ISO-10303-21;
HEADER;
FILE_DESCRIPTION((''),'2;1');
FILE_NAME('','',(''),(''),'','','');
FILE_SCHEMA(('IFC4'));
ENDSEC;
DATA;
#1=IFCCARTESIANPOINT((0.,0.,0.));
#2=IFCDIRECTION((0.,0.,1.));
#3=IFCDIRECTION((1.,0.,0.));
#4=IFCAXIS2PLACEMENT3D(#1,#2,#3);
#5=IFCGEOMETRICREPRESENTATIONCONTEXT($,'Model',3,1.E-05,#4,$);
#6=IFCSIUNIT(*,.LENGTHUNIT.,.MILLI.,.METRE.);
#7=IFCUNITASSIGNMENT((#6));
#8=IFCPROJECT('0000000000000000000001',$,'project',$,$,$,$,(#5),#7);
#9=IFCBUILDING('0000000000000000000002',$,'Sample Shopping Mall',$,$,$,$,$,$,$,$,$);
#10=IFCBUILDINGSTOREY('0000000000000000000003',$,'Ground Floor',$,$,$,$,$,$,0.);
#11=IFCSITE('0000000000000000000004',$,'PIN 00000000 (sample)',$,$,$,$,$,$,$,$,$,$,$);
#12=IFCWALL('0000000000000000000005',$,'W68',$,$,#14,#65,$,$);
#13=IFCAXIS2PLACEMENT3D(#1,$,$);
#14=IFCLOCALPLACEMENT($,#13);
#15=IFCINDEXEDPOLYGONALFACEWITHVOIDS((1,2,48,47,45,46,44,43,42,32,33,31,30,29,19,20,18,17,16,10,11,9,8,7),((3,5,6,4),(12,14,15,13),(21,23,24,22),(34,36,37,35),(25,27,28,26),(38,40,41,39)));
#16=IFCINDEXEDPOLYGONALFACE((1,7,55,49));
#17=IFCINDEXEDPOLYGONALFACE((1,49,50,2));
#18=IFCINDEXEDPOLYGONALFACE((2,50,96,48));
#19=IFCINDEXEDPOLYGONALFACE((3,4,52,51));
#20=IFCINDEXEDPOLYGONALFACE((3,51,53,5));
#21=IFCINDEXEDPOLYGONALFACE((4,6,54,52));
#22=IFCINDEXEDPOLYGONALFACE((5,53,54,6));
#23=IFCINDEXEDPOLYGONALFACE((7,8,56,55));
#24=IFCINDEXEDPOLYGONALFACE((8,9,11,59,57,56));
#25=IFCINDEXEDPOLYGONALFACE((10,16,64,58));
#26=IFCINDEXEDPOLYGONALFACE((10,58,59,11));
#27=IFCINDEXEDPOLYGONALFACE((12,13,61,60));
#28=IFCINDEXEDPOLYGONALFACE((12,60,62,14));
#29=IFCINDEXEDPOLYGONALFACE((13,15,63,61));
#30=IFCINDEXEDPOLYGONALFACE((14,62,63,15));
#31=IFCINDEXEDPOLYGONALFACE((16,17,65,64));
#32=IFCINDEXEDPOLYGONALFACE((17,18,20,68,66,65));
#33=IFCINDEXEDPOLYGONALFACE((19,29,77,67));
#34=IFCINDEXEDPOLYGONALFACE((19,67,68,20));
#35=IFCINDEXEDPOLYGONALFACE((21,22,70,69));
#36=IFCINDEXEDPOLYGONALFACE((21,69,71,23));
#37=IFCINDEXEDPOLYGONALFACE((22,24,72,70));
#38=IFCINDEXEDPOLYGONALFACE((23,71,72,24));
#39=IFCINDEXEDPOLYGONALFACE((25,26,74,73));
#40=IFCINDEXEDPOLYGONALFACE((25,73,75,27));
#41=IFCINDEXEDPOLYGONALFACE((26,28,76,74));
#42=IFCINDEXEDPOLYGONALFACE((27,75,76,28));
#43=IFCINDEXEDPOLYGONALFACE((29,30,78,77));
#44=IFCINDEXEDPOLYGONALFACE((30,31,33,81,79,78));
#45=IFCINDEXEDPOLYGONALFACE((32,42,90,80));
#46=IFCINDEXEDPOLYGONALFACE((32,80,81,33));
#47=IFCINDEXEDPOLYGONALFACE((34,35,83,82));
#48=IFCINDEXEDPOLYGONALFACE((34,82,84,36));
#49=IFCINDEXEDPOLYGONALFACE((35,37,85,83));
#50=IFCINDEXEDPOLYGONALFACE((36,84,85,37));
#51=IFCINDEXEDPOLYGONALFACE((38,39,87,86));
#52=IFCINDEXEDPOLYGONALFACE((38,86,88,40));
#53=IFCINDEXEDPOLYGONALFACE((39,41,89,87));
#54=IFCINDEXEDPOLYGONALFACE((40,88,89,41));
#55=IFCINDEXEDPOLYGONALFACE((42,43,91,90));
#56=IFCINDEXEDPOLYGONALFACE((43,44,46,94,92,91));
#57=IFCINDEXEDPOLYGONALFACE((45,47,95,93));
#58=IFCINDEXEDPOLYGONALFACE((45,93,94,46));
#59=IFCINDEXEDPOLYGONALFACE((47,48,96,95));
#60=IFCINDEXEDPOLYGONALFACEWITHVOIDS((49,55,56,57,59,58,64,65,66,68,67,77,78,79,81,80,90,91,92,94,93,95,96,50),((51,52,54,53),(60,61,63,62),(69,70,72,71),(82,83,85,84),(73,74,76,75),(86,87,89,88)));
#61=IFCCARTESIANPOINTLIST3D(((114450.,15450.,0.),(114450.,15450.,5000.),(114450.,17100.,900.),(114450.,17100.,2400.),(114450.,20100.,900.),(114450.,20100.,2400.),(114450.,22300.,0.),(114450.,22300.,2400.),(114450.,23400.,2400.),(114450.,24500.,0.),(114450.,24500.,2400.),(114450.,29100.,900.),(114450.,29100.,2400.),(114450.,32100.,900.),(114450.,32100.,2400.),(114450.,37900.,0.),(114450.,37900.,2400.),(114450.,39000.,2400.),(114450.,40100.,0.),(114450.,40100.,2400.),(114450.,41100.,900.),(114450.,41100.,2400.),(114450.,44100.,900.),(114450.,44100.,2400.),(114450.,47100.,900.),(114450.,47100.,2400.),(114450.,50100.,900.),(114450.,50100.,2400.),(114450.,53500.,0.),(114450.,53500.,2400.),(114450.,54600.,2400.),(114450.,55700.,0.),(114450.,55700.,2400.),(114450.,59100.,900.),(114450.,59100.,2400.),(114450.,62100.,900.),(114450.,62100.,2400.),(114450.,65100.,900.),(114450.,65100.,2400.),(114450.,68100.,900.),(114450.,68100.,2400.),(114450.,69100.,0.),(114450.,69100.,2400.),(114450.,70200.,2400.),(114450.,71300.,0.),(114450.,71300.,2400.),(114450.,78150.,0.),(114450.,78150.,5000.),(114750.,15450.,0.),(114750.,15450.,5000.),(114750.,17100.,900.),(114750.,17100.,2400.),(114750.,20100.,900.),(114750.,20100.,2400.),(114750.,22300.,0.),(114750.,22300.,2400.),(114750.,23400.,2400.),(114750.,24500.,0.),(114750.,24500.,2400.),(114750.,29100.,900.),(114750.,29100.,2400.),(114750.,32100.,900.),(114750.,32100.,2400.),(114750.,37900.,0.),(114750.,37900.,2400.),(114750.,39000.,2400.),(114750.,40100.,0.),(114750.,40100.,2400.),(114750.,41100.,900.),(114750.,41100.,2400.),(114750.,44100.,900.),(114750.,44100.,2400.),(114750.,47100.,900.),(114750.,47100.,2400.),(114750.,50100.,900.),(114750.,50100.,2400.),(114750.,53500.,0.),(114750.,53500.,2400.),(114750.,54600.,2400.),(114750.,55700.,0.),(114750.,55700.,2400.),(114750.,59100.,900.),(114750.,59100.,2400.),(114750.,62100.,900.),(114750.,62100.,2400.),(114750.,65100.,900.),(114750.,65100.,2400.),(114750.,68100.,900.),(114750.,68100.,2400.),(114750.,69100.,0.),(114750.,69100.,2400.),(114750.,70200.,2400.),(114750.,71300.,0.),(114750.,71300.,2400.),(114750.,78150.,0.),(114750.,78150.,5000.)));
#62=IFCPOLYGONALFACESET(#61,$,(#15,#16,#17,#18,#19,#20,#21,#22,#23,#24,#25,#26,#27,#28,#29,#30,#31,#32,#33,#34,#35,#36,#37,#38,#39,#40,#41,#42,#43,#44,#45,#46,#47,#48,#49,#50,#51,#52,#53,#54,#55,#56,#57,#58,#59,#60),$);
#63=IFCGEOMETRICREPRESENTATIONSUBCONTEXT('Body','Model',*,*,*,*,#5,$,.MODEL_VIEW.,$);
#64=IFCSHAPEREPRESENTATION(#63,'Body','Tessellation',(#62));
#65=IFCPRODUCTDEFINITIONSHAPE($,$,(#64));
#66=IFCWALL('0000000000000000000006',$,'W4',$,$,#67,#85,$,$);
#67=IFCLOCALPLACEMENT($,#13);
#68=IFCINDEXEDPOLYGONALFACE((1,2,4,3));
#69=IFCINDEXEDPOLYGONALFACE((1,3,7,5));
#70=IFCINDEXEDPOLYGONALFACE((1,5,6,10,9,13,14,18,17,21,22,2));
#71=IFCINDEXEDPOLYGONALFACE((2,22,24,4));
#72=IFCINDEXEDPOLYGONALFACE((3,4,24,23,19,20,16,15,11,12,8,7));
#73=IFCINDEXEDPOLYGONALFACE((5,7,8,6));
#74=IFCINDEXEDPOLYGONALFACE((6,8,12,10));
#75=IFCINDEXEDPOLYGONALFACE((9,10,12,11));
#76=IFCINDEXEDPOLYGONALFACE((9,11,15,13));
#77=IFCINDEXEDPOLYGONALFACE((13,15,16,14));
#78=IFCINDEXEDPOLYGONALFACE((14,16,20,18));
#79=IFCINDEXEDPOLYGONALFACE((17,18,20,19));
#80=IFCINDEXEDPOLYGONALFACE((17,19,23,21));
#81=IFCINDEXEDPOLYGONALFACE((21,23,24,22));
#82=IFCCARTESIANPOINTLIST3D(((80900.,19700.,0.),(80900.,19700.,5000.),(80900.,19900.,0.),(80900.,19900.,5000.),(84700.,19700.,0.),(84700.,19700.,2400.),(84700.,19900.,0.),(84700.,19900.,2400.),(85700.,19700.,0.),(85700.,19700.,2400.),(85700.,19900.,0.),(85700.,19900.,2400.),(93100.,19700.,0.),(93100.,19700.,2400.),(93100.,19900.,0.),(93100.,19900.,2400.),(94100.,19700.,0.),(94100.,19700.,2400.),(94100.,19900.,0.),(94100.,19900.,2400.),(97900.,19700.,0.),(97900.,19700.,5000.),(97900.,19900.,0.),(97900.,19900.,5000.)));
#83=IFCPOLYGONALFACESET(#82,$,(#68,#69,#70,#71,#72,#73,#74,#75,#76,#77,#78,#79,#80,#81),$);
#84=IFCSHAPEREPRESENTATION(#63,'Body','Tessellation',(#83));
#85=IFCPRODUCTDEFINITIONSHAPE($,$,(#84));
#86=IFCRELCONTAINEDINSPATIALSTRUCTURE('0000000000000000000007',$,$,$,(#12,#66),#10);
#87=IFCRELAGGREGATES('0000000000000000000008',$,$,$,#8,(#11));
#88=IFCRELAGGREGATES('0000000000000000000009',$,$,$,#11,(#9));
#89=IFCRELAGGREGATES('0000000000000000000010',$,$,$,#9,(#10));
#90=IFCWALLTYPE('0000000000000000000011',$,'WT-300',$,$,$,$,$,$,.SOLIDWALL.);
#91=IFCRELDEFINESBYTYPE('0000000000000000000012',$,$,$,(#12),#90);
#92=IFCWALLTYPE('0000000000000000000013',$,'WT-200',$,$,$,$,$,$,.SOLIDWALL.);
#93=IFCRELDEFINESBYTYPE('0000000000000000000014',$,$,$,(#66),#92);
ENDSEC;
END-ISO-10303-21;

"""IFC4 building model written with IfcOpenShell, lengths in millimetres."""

from ifc_helpers import new_model, si_unit, frame, origin_with_axes, place, context, subcontext, project, spatial, indexed_curve, outline, extrude, type_object, element, save


model = new_model("IFC4")

# Units and contexts
model_context = context("Model", 3, precision=1e-05, world=origin_with_axes())
body_context = subcontext(model_context, "Body", "Model", "MODEL_VIEW")
ifc_project = project(units=[si_unit("LENGTHUNIT", "METRE", prefix="MILLI")], contexts=[model_context])

# Site, building, storey
site = spatial("IfcSite", under=ifc_project, Name="PIN 00000000 (sample)")
building = spatial("IfcBuilding", under=site, Name="Sample Shopping Mall")
storey = spatial("IfcBuildingStorey", under=building, Name="Ground Floor", Elevation=0.0)

# Walls, openings
wall_type_1 = type_object("IfcWallType", Name="WT-300", PredefinedType="SOLIDWALL")
wall_1_placement = place(None, frame((114750.0, 15450.0, 0.0), z_axis=(0.0, 0.0, 1.0), x_axis=(0.0, 1.0, 0.0)))
wall_1 = element("IfcWall", 1, at=wall_1_placement, inside=storey, type_object=wall_type_1, Name="W68", context=body_context, shape_type="SweptSolid", body=[
    extrude(outline(indexed_curve([(0.0, 0.0), (0.0, 300.0), (62700.0, 300.0), (62700.0, 0.0), (0.0, 0.0)], self_intersect=False)), origin_with_axes(), (0.0, 0.0, 1.0), 5000.0),
])
opening_1_placement = place(wall_1_placement, frame((6850.0, -100.0, 0.0), z_axis=(0.0, 0.0, 1.0), x_axis=(1.0, 0.0, 0.0)))
element("IfcOpeningElement", 2, at=opening_1_placement, cuts=wall_1, context=body_context, shape_type="SweptSolid", body=[
    extrude(outline(indexed_curve([(0.0, 0.0), (0.0, 500.0), (1100.0, 500.0), (1100.0, 0.0), (0.0, 0.0)], self_intersect=False)), origin_with_axes(), (0.0, 0.0, 1.0), 2400.0),
])
opening_2_placement = place(wall_1_placement, frame((7950.0, -100.0, 0.0), z_axis=(0.0, 0.0, 1.0), x_axis=(1.0, 0.0, 0.0)))
element("IfcOpeningElement", 3, at=opening_2_placement, cuts=wall_1, context=body_context, shape_type="SweptSolid", body=[
    extrude(outline(indexed_curve([(0.0, 0.0), (0.0, 500.0), (1100.0, 500.0), (1100.0, 0.0), (0.0, 0.0)], self_intersect=False)), origin_with_axes(), (0.0, 0.0, 1.0), 2400.0),
])
opening_3_placement = place(wall_1_placement, frame((22450.0, -100.0, 0.0), z_axis=(0.0, 0.0, 1.0), x_axis=(1.0, 0.0, 0.0)))
element("IfcOpeningElement", 4, at=opening_3_placement, cuts=wall_1, context=body_context, shape_type="SweptSolid", body=[
    extrude(outline(indexed_curve([(0.0, 0.0), (0.0, 500.0), (1100.0, 500.0), (1100.0, 0.0), (0.0, 0.0)], self_intersect=False)), origin_with_axes(), (0.0, 0.0, 1.0), 2400.0),
])
opening_4_placement = place(wall_1_placement, frame((23550.0, -100.0, 0.0), z_axis=(0.0, 0.0, 1.0), x_axis=(1.0, 0.0, 0.0)))
element("IfcOpeningElement", 5, at=opening_4_placement, cuts=wall_1, context=body_context, shape_type="SweptSolid", body=[
    extrude(outline(indexed_curve([(0.0, 0.0), (0.0, 500.0), (1100.0, 500.0), (1100.0, 0.0), (0.0, 0.0)], self_intersect=False)), origin_with_axes(), (0.0, 0.0, 1.0), 2400.0),
])
opening_5_placement = place(wall_1_placement, frame((38050.0, -100.0, 0.0), z_axis=(0.0, 0.0, 1.0), x_axis=(1.0, 0.0, 0.0)))
element("IfcOpeningElement", 6, at=opening_5_placement, cuts=wall_1, context=body_context, shape_type="SweptSolid", body=[
    extrude(outline(indexed_curve([(0.0, 0.0), (0.0, 500.0), (1100.0, 500.0), (1100.0, 0.0), (0.0, 0.0)], self_intersect=False)), origin_with_axes(), (0.0, 0.0, 1.0), 2400.0),
])
opening_6_placement = place(wall_1_placement, frame((39150.0, -100.0, 0.0), z_axis=(0.0, 0.0, 1.0), x_axis=(1.0, 0.0, 0.0)))
element("IfcOpeningElement", 7, at=opening_6_placement, cuts=wall_1, context=body_context, shape_type="SweptSolid", body=[
    extrude(outline(indexed_curve([(0.0, 0.0), (0.0, 500.0), (1100.0, 500.0), (1100.0, 0.0), (0.0, 0.0)], self_intersect=False)), origin_with_axes(), (0.0, 0.0, 1.0), 2400.0),
])
opening_7_placement = place(wall_1_placement, frame((53650.0, -100.0, 0.0), z_axis=(0.0, 0.0, 1.0), x_axis=(1.0, 0.0, 0.0)))
element("IfcOpeningElement", 8, at=opening_7_placement, cuts=wall_1, context=body_context, shape_type="SweptSolid", body=[
    extrude(outline(indexed_curve([(0.0, 0.0), (0.0, 500.0), (1100.0, 500.0), (1100.0, 0.0), (0.0, 0.0)], self_intersect=False)), origin_with_axes(), (0.0, 0.0, 1.0), 2400.0),
])
opening_8_placement = place(wall_1_placement, frame((54750.0, -100.0, 0.0), z_axis=(0.0, 0.0, 1.0), x_axis=(1.0, 0.0, 0.0)))
element("IfcOpeningElement", 9, at=opening_8_placement, cuts=wall_1, context=body_context, shape_type="SweptSolid", body=[
    extrude(outline(indexed_curve([(0.0, 0.0), (0.0, 500.0), (1100.0, 500.0), (1100.0, 0.0), (0.0, 0.0)], self_intersect=False)), origin_with_axes(), (0.0, 0.0, 1.0), 2400.0),
])
opening_9_placement = place(wall_1_placement, frame((1650.0, -100.0, 900.0), z_axis=(0.0, 0.0, 1.0), x_axis=(1.0, 0.0, 0.0)))
element("IfcOpeningElement", 10, at=opening_9_placement, cuts=wall_1, context=body_context, shape_type="SweptSolid", body=[
    extrude(outline(indexed_curve([(0.0, 0.0), (0.0, 500.0), (3000.0, 500.0), (3000.0, 0.0), (0.0, 0.0)], self_intersect=False)), origin_with_axes(), (0.0, 0.0, 1.0), 1500.0),
])
opening_10_placement = place(wall_1_placement, frame((13650.0, -100.0, 900.0), z_axis=(0.0, 0.0, 1.0), x_axis=(1.0, 0.0, 0.0)))
element("IfcOpeningElement", 11, at=opening_10_placement, cuts=wall_1, context=body_context, shape_type="SweptSolid", body=[
    extrude(outline(indexed_curve([(0.0, 0.0), (0.0, 500.0), (3000.0, 500.0), (3000.0, 0.0), (0.0, 0.0)], self_intersect=False)), origin_with_axes(), (0.0, 0.0, 1.0), 1500.0),
])
opening_11_placement = place(wall_1_placement, frame((25650.0, -100.0, 900.0), z_axis=(0.0, 0.0, 1.0), x_axis=(1.0, 0.0, 0.0)))
element("IfcOpeningElement", 12, at=opening_11_placement, cuts=wall_1, context=body_context, shape_type="SweptSolid", body=[
    extrude(outline(indexed_curve([(0.0, 0.0), (0.0, 500.0), (3000.0, 500.0), (3000.0, 0.0), (0.0, 0.0)], self_intersect=False)), origin_with_axes(), (0.0, 0.0, 1.0), 1500.0),
])
opening_12_placement = place(wall_1_placement, frame((31650.0, -100.0, 900.0), z_axis=(0.0, 0.0, 1.0), x_axis=(1.0, 0.0, 0.0)))
element("IfcOpeningElement", 13, at=opening_12_placement, cuts=wall_1, context=body_context, shape_type="SweptSolid", body=[
    extrude(outline(indexed_curve([(0.0, 0.0), (0.0, 500.0), (3000.0, 500.0), (3000.0, 0.0), (0.0, 0.0)], self_intersect=False)), origin_with_axes(), (0.0, 0.0, 1.0), 1500.0),
])
opening_13_placement = place(wall_1_placement, frame((43650.0, -100.0, 900.0), z_axis=(0.0, 0.0, 1.0), x_axis=(1.0, 0.0, 0.0)))
element("IfcOpeningElement", 14, at=opening_13_placement, cuts=wall_1, context=body_context, shape_type="SweptSolid", body=[
    extrude(outline(indexed_curve([(0.0, 0.0), (0.0, 500.0), (3000.0, 500.0), (3000.0, 0.0), (0.0, 0.0)], self_intersect=False)), origin_with_axes(), (0.0, 0.0, 1.0), 1500.0),
])
opening_14_placement = place(wall_1_placement, frame((49650.0, -100.0, 900.0), z_axis=(0.0, 0.0, 1.0), x_axis=(1.0, 0.0, 0.0)))
element("IfcOpeningElement", 15, at=opening_14_placement, cuts=wall_1, context=body_context, shape_type="SweptSolid", body=[
    extrude(outline(indexed_curve([(0.0, 0.0), (0.0, 500.0), (3000.0, 500.0), (3000.0, 0.0), (0.0, 0.0)], self_intersect=False)), origin_with_axes(), (0.0, 0.0, 1.0), 1500.0),
])
wall_type_2 = type_object("IfcWallType", Name="WT-200", PredefinedType="SOLIDWALL")
wall_2_placement = place(None, frame((80900.0, 19700.0, 0.0), z_axis=(0.0, 0.0, 1.0), x_axis=(1.0, 0.0, 0.0)))
wall_2 = element("IfcWall", 16, at=wall_2_placement, inside=storey, type_object=wall_type_2, Name="W4", context=body_context, shape_type="SweptSolid", body=[
    extrude(outline(indexed_curve([(0.0, 0.0), (0.0, 200.0), (17000.0, 200.0), (17000.0, 0.0), (0.0, 0.0)], self_intersect=False)), origin_with_axes(), (0.0, 0.0, 1.0), 5000.0),
])
opening_15_placement = place(wall_2_placement, frame((3800.0, -100.0, 0.0), z_axis=(0.0, 0.0, 1.0), x_axis=(1.0, 0.0, 0.0)))
element("IfcOpeningElement", 17, at=opening_15_placement, cuts=wall_2, context=body_context, shape_type="SweptSolid", body=[
    extrude(outline(indexed_curve([(0.0, 0.0), (0.0, 400.0), (1000.0, 400.0), (1000.0, 0.0), (0.0, 0.0)], self_intersect=False)), origin_with_axes(), (0.0, 0.0, 1.0), 2400.0),
])
opening_16_placement = place(wall_2_placement, frame((12200.0, -100.0, 0.0), z_axis=(0.0, 0.0, 1.0), x_axis=(1.0, 0.0, 0.0)))
element("IfcOpeningElement", 18, at=opening_16_placement, cuts=wall_2, context=body_context, shape_type="SweptSolid", body=[
    extrude(outline(indexed_curve([(0.0, 0.0), (0.0, 400.0), (1000.0, 400.0), (1000.0, 0.0), (0.0, 0.0)], self_intersect=False)), origin_with_axes(), (0.0, 0.0, 1.0), 2400.0),
])

save(model, "model.ifc")
